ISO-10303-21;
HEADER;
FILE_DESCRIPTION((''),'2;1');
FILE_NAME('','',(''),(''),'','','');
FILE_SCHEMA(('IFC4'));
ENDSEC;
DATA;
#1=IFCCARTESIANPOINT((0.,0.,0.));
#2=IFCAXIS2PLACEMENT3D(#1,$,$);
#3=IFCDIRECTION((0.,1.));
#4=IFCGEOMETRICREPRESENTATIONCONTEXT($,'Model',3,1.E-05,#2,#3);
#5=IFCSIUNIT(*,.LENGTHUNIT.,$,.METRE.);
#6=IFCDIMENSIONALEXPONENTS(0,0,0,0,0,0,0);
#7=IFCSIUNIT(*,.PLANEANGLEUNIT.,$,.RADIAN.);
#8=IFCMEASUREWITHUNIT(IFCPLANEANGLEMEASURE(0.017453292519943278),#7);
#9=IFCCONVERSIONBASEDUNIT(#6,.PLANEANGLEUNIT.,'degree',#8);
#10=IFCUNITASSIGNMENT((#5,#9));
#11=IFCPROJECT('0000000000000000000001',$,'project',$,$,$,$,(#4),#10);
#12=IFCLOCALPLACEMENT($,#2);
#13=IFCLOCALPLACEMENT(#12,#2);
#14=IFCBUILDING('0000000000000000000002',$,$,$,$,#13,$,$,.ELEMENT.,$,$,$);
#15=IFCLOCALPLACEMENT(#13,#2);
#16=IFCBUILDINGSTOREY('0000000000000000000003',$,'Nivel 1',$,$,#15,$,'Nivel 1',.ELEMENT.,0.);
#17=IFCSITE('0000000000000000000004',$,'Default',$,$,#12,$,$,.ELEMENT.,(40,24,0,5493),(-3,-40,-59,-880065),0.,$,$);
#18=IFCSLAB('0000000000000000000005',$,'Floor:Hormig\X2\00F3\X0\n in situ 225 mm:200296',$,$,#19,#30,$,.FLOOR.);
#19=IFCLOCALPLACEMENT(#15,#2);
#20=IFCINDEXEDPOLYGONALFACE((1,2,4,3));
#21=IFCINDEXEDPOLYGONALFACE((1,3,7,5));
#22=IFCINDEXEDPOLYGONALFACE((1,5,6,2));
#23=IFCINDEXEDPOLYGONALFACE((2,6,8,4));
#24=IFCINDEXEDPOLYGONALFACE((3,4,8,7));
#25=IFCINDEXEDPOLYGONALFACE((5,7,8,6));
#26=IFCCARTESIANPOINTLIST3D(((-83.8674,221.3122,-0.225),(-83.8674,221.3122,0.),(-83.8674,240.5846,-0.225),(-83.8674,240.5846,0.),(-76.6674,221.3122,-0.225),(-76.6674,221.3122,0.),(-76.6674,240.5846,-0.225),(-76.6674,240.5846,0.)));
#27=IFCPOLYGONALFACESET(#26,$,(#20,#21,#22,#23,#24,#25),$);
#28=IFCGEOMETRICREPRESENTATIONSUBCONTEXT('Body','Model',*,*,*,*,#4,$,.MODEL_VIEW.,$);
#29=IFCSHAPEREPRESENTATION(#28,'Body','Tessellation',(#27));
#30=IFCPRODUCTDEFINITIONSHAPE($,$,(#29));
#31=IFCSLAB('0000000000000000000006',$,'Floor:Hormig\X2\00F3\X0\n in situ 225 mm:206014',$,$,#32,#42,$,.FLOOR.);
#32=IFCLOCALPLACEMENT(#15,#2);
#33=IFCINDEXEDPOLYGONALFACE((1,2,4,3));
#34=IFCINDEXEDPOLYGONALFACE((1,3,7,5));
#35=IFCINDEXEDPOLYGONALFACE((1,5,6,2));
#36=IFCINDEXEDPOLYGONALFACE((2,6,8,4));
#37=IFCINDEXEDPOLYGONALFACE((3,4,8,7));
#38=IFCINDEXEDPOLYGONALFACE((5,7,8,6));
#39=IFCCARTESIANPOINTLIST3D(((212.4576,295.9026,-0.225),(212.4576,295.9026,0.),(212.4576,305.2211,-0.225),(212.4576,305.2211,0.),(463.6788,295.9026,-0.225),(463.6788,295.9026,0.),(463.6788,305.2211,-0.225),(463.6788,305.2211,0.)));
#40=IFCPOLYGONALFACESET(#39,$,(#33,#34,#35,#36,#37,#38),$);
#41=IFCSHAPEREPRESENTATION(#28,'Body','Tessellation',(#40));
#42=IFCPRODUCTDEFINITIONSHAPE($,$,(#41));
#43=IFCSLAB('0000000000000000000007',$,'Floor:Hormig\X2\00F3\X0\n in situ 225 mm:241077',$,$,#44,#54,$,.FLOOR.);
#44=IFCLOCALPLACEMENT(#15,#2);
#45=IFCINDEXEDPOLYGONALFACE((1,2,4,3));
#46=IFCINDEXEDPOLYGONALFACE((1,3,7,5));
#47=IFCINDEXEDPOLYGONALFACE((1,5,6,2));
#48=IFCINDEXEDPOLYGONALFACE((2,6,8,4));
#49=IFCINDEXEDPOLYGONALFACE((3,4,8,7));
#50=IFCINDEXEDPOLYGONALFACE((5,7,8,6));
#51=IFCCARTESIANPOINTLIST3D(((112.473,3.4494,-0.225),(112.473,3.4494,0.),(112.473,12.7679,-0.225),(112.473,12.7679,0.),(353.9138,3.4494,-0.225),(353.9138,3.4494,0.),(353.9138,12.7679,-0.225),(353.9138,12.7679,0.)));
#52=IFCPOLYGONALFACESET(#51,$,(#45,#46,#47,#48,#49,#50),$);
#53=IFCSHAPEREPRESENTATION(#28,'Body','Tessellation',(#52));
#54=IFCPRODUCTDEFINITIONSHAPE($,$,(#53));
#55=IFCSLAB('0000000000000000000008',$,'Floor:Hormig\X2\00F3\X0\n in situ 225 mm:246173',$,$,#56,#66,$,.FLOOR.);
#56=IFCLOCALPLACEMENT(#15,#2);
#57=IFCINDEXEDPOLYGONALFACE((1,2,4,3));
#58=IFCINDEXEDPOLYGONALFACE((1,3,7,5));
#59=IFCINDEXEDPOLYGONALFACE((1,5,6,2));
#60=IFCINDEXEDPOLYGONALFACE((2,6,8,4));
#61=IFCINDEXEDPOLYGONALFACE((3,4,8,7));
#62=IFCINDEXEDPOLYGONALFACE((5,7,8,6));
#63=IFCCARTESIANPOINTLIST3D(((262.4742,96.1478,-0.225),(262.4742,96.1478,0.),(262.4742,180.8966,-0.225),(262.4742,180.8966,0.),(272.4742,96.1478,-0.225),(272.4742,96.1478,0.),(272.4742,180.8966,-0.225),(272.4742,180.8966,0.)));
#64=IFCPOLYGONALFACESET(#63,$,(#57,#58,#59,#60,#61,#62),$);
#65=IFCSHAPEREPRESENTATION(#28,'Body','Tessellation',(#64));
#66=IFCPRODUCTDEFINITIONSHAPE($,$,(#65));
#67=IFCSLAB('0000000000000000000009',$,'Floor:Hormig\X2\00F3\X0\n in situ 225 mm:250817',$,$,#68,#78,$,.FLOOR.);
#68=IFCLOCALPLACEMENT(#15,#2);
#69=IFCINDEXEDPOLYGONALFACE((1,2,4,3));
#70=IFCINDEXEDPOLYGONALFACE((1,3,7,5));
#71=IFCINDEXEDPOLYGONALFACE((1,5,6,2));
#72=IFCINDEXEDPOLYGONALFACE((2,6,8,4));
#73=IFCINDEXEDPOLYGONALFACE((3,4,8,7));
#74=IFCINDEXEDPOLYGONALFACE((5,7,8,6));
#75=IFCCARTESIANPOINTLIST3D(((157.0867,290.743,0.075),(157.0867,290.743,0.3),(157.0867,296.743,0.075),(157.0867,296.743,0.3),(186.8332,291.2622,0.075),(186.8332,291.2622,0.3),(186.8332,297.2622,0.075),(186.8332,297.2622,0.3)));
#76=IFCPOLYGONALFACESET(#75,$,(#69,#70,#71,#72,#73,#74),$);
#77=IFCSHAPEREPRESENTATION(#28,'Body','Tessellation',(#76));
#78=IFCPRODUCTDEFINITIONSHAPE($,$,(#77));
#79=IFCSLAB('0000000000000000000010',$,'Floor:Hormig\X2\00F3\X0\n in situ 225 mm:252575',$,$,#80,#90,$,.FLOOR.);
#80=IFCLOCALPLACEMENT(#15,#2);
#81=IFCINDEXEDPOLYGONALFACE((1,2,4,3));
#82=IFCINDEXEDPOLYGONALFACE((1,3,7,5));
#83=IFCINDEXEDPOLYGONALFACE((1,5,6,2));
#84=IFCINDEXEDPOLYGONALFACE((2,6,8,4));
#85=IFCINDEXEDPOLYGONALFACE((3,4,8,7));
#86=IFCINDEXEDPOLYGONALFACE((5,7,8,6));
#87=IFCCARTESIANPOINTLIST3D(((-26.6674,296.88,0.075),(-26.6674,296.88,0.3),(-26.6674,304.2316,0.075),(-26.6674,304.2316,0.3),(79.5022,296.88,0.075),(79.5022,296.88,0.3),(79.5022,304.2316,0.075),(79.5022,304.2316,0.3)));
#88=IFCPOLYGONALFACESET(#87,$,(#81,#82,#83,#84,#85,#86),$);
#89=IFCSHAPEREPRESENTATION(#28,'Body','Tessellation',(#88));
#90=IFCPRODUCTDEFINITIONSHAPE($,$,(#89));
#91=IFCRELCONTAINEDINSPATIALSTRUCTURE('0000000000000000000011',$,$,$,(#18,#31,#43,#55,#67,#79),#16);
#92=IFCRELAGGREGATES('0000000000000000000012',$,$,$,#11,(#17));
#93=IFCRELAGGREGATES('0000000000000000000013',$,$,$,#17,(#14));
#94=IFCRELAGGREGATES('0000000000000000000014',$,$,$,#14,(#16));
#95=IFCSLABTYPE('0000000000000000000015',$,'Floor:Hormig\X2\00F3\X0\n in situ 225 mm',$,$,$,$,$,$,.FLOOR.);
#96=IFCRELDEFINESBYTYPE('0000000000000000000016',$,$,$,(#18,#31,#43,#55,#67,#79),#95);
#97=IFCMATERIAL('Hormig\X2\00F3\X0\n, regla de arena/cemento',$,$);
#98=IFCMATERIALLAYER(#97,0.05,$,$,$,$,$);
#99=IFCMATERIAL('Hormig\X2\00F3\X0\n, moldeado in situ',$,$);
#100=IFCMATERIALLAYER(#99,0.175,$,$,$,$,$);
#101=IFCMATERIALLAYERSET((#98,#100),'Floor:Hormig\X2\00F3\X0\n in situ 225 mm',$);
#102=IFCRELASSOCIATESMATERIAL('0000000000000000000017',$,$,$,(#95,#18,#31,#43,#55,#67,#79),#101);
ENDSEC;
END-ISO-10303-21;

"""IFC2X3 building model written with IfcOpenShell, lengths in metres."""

from ifc_helpers import new_model, entity, si_unit, converted_unit, direction, frame, frame_2d, origin, origin_2d_with_axis, place, context, subcontext, project, spatial, polyline, rectangle, outline, extrude, material, layer, layer_set, layer_usage, type_object, element, save


model = new_model("IFC2X3")

# Units and contexts
model_context = context("Model", 3, precision=1e-05, world=origin(), true_north=direction((0.0, 1.0)))
body_context = subcontext(model_context, "Body", "Model", "MODEL_VIEW")
ifc_project = project(units=[si_unit("LENGTHUNIT", "METRE"), converted_unit("PLANEANGLEUNIT", "degree", entity("IfcPlaneAngleMeasure", 0.017453292519943278), si_unit("PLANEANGLEUNIT", "RADIAN"), dimensions=[0, 0, 0, 0, 0, 0, 0])], contexts=[model_context])

# Site, building, storey
site_placement = place(None, origin())
site = spatial("IfcSite", under=ifc_project, at=site_placement, Name="Default", CompositionType="ELEMENT", RefLatitude=(40, 24, 0, 5493), RefLongitude=(-3, -40, -59, -880065), RefElevation=0.0)
building_placement = place(site_placement, origin())
building = spatial("IfcBuilding", under=site, at=building_placement, CompositionType="ELEMENT")
storey_placement = place(building_placement, origin())
storey = spatial("IfcBuildingStorey", under=building, at=storey_placement, Name="Nivel 1", LongName="Nivel 1", CompositionType="ELEMENT", Elevation=0.0)

# Slabs
ifc_material_1 = material(Name="Hormigón, regla de arena/cemento")
ifc_layer_1 = layer(ifc_material_1, 0.05)
ifc_material_2 = material(Name="Hormigón, moldeado in situ")
ifc_layer_2 = layer(ifc_material_2, 0.175)
ifc_layer_set = layer_set([ifc_layer_1, ifc_layer_2], Name="Floor:Hormigón in situ 225 mm")
ifc_layer_usage_1 = layer_usage(ifc_layer_set, "AXIS3", "POSITIVE", 0.0)
slab_type = type_object("IfcSlabType", Name="Floor:Hormigón in situ 225 mm", PredefinedType="FLOOR", material=ifc_layer_set)
slab_1_placement = place(storey_placement, origin())
element("IfcSlab", 1, at=slab_1_placement, inside=storey, type_object=slab_type, material=ifc_layer_usage_1, Name="Floor:Hormigón in situ 225 mm:200296", PredefinedType="FLOOR", context=body_context, shape_type="SweptSolid", body=[
    extrude(rectangle(XDim=19.2724, YDim=7.2, at=frame_2d((0.0, 0.0), x_axis=(1.0, 0.0))), frame((-80.2674, 230.9484, 0.0), z_axis=(0.0, 0.0, -1.0), x_axis=(0.0, 1.0, 0.0)), (0.0, 0.0, 1.0), 0.225),
])
ifc_layer_usage_2 = layer_usage(ifc_layer_set, "AXIS3", "POSITIVE", 0.0)
slab_2_placement = place(storey_placement, origin())
element("IfcSlab", 2, at=slab_2_placement, inside=storey, type_object=slab_type, material=ifc_layer_usage_2, Name="Floor:Hormigón in situ 225 mm:206014", PredefinedType="FLOOR", context=body_context, shape_type="SweptSolid", body=[
    extrude(rectangle(XDim=9.3185, YDim=251.2212, at=frame_2d((0.0, 0.0), x_axis=(1.0, 0.0))), frame((338.0682, 300.5619, 0.0), z_axis=(0.0, 0.0, -1.0), x_axis=(0.0, 1.0, 0.0)), (0.0, 0.0, 1.0), 0.225),
])
ifc_layer_usage_3 = layer_usage(ifc_layer_set, "AXIS3", "POSITIVE", 0.0)
slab_3_placement = place(storey_placement, origin())
element("IfcSlab", 3, at=slab_3_placement, inside=storey, type_object=slab_type, material=ifc_layer_usage_3, Name="Floor:Hormigón in situ 225 mm:241077", PredefinedType="FLOOR", context=body_context, shape_type="SweptSolid", body=[
    extrude(rectangle(XDim=9.3185, YDim=241.4407, at=frame_2d((0.0, 0.0), x_axis=(1.0, 0.0))), frame((233.1934, 8.1087, 0.0), z_axis=(0.0, 0.0, -1.0), x_axis=(0.0, 1.0, 0.0)), (0.0, 0.0, 1.0), 0.225),
])
ifc_layer_usage_4 = layer_usage(ifc_layer_set, "AXIS3", "POSITIVE", 0.0)
slab_4_placement = place(storey_placement, origin())
element("IfcSlab", 4, at=slab_4_placement, inside=storey, type_object=slab_type, material=ifc_layer_usage_4, Name="Floor:Hormigón in situ 225 mm:246173", PredefinedType="FLOOR", context=body_context, shape_type="SweptSolid", body=[
    extrude(rectangle(XDim=84.7488, YDim=10.0, at=origin_2d_with_axis()), frame((267.4742, 138.5222, 0.0), z_axis=(0.0, 0.0, -1.0), x_axis=(0.0, 1.0, 0.0)), (0.0, 0.0, 1.0), 0.225),
])
ifc_layer_usage_5 = layer_usage(ifc_layer_set, "AXIS3", "POSITIVE", 0.0)
slab_5_placement = place(storey_placement, origin())
element("IfcSlab", 5, at=slab_5_placement, inside=storey, type_object=slab_type, material=ifc_layer_usage_5, Name="Floor:Hormigón in situ 225 mm:250817", PredefinedType="FLOOR", context=body_context, shape_type="SweptSolid", body=[
    extrude(outline(polyline([(-3.2596, -14.8732), (2.7404, -14.8732), (3.2596, 14.8732), (-2.7404, 14.8732), (-3.2596, -14.8732)])), frame((171.9599, 294.0026, 0.3), z_axis=(0.0, 0.0, -1.0), x_axis=(0.0, 1.0, 0.0)), (0.0, 0.0, 1.0), 0.225),
])
ifc_layer_usage_6 = layer_usage(ifc_layer_set, "AXIS3", "POSITIVE", 0.0)
slab_6_placement = place(storey_placement, origin())
element("IfcSlab", 6, at=slab_6_placement, inside=storey, type_object=slab_type, material=ifc_layer_usage_6, Name="Floor:Hormigón in situ 225 mm:252575", PredefinedType="FLOOR", context=body_context, shape_type="SweptSolid", body=[
    extrude(rectangle(XDim=7.3517, YDim=106.1696, at=frame_2d((0.0, 0.0), x_axis=(1.0, 0.0))), frame((26.4174, 300.5558, 0.3), z_axis=(0.0, 0.0, -1.0), x_axis=(0.0, 1.0, 0.0)), (0.0, 0.0, 1.0), 0.225),
])

save(model, "model.ifc")
